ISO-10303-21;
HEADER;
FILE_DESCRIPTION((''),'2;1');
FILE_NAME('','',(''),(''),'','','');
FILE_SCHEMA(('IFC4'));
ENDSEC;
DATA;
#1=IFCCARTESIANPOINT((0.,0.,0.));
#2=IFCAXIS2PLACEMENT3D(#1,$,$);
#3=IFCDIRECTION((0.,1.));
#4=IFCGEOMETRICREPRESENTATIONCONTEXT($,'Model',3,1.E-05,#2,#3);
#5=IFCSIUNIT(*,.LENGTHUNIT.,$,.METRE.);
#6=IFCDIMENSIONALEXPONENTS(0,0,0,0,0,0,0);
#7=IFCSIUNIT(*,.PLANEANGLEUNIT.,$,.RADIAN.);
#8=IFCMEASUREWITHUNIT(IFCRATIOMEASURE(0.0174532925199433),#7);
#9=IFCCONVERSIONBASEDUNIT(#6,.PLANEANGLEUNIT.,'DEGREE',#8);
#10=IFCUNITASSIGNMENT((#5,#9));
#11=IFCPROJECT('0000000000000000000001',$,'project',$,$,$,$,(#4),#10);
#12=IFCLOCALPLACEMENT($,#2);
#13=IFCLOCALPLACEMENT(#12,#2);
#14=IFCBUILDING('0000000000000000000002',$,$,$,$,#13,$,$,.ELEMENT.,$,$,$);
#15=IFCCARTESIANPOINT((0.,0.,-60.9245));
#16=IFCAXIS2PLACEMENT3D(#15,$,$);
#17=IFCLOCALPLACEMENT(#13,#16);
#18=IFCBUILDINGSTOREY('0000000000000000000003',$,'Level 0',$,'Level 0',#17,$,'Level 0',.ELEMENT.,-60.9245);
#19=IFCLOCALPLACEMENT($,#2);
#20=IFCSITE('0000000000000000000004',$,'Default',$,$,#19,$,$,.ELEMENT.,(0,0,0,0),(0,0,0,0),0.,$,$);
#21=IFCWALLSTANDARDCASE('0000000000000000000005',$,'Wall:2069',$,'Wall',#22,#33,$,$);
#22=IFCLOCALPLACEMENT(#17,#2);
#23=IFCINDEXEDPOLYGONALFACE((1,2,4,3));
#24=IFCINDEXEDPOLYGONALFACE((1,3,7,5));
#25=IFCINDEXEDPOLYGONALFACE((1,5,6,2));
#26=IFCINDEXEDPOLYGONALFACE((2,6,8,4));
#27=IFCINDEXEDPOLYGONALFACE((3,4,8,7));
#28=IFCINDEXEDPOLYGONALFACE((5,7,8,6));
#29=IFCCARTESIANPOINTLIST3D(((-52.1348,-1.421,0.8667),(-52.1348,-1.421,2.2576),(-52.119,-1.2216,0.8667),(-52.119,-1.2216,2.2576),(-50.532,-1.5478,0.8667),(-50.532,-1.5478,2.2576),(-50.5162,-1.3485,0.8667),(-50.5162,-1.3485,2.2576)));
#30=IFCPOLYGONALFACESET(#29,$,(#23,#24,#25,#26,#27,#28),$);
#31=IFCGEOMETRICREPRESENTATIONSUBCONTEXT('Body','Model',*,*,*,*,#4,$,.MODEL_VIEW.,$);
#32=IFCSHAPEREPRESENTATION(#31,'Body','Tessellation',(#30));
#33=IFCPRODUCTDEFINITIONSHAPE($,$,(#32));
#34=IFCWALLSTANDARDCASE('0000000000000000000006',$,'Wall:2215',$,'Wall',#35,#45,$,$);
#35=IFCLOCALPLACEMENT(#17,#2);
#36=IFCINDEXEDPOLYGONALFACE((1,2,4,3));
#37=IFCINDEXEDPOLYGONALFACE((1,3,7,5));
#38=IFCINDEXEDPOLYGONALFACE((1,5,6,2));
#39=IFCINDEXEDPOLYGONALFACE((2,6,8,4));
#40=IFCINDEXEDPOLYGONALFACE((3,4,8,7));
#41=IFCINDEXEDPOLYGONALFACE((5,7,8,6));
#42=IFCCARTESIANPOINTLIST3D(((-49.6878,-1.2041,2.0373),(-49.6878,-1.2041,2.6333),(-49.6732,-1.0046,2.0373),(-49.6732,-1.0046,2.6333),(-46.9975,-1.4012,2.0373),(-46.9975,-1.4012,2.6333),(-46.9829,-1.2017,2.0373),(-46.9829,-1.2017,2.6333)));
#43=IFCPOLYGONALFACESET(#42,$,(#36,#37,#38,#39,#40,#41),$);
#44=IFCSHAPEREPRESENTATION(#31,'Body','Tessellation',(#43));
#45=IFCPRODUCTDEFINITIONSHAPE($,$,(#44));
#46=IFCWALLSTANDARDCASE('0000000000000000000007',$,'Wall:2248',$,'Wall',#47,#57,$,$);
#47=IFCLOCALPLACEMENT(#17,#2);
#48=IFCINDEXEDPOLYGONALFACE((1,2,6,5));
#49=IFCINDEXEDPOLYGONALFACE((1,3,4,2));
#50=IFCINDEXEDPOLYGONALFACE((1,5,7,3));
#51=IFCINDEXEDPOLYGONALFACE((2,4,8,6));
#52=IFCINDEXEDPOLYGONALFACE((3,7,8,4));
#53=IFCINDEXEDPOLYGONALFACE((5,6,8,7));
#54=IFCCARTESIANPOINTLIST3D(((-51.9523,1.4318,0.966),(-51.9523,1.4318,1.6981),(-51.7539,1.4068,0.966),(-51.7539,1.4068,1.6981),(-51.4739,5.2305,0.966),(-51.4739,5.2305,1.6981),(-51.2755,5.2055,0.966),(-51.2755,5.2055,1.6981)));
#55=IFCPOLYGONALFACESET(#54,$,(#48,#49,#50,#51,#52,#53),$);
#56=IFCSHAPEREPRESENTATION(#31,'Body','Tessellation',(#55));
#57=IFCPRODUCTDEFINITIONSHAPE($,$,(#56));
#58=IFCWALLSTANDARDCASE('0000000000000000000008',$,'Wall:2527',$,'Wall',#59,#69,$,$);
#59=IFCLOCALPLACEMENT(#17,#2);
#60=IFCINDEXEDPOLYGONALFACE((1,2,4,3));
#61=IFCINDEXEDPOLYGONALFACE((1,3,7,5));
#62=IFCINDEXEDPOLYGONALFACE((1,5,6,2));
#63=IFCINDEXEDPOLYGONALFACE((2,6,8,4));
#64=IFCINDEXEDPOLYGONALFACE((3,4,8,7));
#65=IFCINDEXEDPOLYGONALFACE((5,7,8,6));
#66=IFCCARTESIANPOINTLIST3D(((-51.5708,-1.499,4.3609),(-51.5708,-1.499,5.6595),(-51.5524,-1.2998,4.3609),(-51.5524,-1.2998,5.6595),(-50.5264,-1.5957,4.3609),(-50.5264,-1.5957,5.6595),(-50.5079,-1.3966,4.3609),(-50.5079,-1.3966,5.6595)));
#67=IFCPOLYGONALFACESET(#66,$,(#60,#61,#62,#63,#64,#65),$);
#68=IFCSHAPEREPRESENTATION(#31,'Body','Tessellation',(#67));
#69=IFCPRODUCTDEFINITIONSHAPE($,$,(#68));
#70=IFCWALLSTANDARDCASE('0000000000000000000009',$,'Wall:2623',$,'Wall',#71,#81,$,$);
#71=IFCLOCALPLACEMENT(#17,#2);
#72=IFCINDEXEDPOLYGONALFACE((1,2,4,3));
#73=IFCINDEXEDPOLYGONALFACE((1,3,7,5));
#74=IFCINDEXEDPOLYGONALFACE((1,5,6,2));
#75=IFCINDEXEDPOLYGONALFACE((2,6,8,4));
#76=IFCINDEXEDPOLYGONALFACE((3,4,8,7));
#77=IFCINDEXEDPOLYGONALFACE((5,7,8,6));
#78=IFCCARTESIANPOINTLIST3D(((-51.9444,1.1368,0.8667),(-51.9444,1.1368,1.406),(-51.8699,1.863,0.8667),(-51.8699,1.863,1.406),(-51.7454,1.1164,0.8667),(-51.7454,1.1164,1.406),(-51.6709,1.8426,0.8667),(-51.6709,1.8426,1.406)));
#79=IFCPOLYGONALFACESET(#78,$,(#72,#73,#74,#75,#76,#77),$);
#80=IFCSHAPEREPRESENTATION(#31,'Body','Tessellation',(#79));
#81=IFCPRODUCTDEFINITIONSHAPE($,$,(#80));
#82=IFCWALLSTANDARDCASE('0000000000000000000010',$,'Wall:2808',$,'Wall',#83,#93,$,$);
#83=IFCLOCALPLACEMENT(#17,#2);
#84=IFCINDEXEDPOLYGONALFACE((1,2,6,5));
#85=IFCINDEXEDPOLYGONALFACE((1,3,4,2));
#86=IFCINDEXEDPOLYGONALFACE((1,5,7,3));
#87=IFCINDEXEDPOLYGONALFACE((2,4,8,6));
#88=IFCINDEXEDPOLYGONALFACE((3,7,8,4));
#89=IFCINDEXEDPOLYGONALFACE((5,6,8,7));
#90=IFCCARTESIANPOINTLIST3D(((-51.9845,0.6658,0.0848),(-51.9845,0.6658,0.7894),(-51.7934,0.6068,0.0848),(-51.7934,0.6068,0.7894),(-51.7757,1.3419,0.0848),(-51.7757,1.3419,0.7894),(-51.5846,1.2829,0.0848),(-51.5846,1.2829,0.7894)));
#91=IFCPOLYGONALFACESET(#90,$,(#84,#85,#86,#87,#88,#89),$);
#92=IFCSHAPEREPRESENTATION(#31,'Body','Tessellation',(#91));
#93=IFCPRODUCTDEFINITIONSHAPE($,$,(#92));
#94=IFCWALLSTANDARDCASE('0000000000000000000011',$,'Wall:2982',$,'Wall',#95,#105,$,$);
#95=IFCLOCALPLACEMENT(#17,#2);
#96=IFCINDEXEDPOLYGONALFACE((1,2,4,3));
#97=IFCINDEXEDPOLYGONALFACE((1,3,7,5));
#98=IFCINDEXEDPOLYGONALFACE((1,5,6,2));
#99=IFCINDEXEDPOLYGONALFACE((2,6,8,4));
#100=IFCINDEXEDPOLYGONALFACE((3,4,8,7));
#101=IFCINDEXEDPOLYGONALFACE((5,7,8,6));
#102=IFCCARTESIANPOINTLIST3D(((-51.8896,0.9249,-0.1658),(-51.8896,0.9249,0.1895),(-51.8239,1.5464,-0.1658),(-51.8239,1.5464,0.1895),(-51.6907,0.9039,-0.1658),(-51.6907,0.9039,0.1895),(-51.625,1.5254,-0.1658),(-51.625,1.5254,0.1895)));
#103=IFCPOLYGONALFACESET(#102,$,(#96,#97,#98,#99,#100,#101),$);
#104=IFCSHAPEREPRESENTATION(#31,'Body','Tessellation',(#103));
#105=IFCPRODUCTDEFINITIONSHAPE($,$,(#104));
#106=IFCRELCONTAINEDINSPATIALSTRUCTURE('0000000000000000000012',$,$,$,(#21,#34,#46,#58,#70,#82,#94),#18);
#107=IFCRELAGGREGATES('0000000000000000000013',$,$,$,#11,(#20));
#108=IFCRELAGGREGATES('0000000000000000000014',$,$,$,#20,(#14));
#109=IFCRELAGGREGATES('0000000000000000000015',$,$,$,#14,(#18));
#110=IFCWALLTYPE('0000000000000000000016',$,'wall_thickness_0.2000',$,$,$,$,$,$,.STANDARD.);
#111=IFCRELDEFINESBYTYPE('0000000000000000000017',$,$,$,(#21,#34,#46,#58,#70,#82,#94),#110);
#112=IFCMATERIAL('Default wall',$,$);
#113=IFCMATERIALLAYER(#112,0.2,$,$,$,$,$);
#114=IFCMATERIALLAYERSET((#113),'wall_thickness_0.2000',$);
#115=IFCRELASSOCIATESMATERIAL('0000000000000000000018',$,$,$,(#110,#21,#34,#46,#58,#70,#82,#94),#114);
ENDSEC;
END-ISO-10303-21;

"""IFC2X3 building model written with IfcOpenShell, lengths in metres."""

from ifc_helpers import new_model, entity, si_unit, converted_unit, direction, frame, origin, place, context, subcontext, project, spatial, polyline, outline, extrude, material, layer, layer_set, layer_usage, type_object, element, save


model = new_model("IFC2X3")

# Units and contexts
model_context = context("Model", 3, precision=1e-05, world=origin(), true_north=direction((0.0, 1.0)))
body_context = subcontext(model_context, "Body", "Model", "MODEL_VIEW")
ifc_project = project(units=[si_unit("LENGTHUNIT", "METRE"), converted_unit("PLANEANGLEUNIT", "DEGREE", entity("IfcRatioMeasure", 0.0174532925199433), si_unit("PLANEANGLEUNIT", "RADIAN"), dimensions=[0, 0, 0, 0, 0, 0, 0])], contexts=[model_context])

# Site, building, storey
site_placement = place(None, origin())
site = spatial("IfcSite", under=ifc_project, at=site_placement, Name="Default", CompositionType="ELEMENT", RefLatitude=(0, 0, 0, 0), RefLongitude=(0, 0, 0, 0), RefElevation=0.0)
placement_1 = place(None, origin())
building_placement = place(placement_1, origin())
building = spatial("IfcBuilding", under=site, at=building_placement, CompositionType="ELEMENT")
storey_placement = place(building_placement, frame((0.0, 0.0, -60.9245)))
storey = spatial("IfcBuildingStorey", under=building, at=storey_placement, Name="Level 0", ObjectType="Level 0", LongName="Level 0", CompositionType="ELEMENT", Elevation=-60.9245)

# Walls
ifc_material = material(Name="Default wall")
ifc_layer = layer(ifc_material, 0.2)
ifc_layer_set = layer_set([ifc_layer], Name="wall_thickness_0.2000")
ifc_layer_usage = layer_usage(ifc_layer_set, "AXIS2", "POSITIVE", -0.1)
wall_type = type_object("IfcWallType", Name="wall_thickness_0.2000", PredefinedType="STANDARD", material=ifc_layer_set)
placement_2 = place(building_placement, frame((0.0, 0.0, -60.0578)))
wall_1_placement = place(placement_2, frame((-50.5241, -1.4482, 0.0), z_axis=(0.0, 0.0, 1.0), x_axis=(-0.996884, 0.078885, 0.0)))
element("IfcWallStandardCase", 1, at=wall_1_placement, inside=storey, type_object=wall_type, material=ifc_layer_usage, Name="Wall:2069", ObjectType="Wall", context=body_context, shape_type="SweptSolid", body=[
    extrude(outline(polyline([(1.6078, -0.1), (1.6078, 0.1), (0.0, 0.1), (0.0, -0.1), (1.6078, -0.1)])), origin(), (0.0, 0.0, 1.0), 1.3909),
])
placement_3 = place(building_placement, frame((0.0, 0.0, -58.8872)))
wall_2_placement = place(placement_3, frame((-49.6805, -1.1044, 0.0), z_axis=(0.0, 0.0, 1.0), x_axis=(0.997327, -0.073063, 0.0)))
element("IfcWallStandardCase", 2, at=wall_2_placement, inside=storey, type_object=wall_type, material=ifc_layer_usage, Name="Wall:2215", ObjectType="Wall", context=body_context, shape_type="SweptSolid", body=[
    extrude(outline(polyline([(2.6975, -0.1), (2.6975, 0.1), (0.0, 0.1), (0.0, -0.1), (2.6975, -0.1)])), origin(), (0.0, 0.0, 1.0), 0.596),
])
placement_4 = place(building_placement, frame((0.0, 0.0, -59.9585)))
wall_3_placement = place(placement_4, frame((-51.8531, 1.4193, 0.0), z_axis=(0.0, 0.0, 1.0), x_axis=(0.124951, 0.992163, 0.0)))
element("IfcWallStandardCase", 3, at=wall_3_placement, inside=storey, type_object=wall_type, material=ifc_layer_usage, Name="Wall:2248", ObjectType="Wall", context=body_context, shape_type="SweptSolid", body=[
    extrude(outline(polyline([(3.8288, -0.1), (3.8288, 0.1), (0.0, 0.1), (0.0, -0.1), (3.8288, -0.1)])), origin(), (0.0, 0.0, 1.0), 0.7321),
])
placement_5 = place(building_placement, frame((0.0, 0.0, -56.5636)))
wall_4_placement = place(placement_5, frame((-51.5616, -1.3994, 0.0), z_axis=(0.0, 0.0, 1.0), x_axis=(0.995739, -0.09222, 0.0)))
element("IfcWallStandardCase", 4, at=wall_4_placement, inside=storey, type_object=wall_type, material=ifc_layer_usage, Name="Wall:2527", ObjectType="Wall", context=body_context, shape_type="SweptSolid", body=[
    extrude(outline(polyline([(1.0489, -0.1), (1.0489, 0.1), (0.0, 0.1), (0.0, -0.1), (1.0489, -0.1)])), origin(), (0.0, 0.0, 1.0), 1.2985),
])
placement_6 = place(building_placement, frame((0.0, 0.0, -60.0578)))
wall_5_placement = place(placement_6, frame((-51.8449, 1.1266, 0.0), z_axis=(0.0, 0.0, 1.0), x_axis=(0.102082, 0.994776, 0.0)))
element("IfcWallStandardCase", 5, at=wall_5_placement, inside=storey, type_object=wall_type, material=ifc_layer_usage, Name="Wall:2623", ObjectType="Wall", context=body_context, shape_type="SweptSolid", body=[
    extrude(outline(polyline([(0.73, -0.1), (0.73, 0.1), (0.0, 0.1), (0.0, -0.1), (0.73, -0.1)])), origin(), (0.0, 0.0, 1.0), 0.5393),
])
placement_7 = place(building_placement, frame((0.0, 0.0, -60.8397)))
wall_6_placement = place(placement_7, frame((-51.6802, 1.3124, 0.0), z_axis=(0.0, 0.0, 1.0), x_axis=(-0.295057, -0.95548, 0.0)))
element("IfcWallStandardCase", 6, at=wall_6_placement, inside=storey, type_object=wall_type, material=ifc_layer_usage, Name="Wall:2808", ObjectType="Wall", context=body_context, shape_type="SweptSolid", body=[
    extrude(outline(polyline([(0.7076, -0.1), (0.7076, 0.1), (0.0, 0.1), (0.0, -0.1), (0.7076, -0.1)])), origin(), (0.0, 0.0, 1.0), 0.7047),
])
placement_8 = place(building_placement, frame((0.0, 0.0, -61.0903)))
wall_7_placement = place(placement_8, frame((-51.7245, 1.5359, 0.0), z_axis=(0.0, 0.0, 1.0), x_axis=(-0.105121, -0.994459, 0.0)))
element("IfcWallStandardCase", 7, at=wall_7_placement, inside=storey, type_object=wall_type, material=ifc_layer_usage, Name="Wall:2982", ObjectType="Wall", context=body_context, shape_type="SweptSolid", body=[
    extrude(outline(polyline([(0.625, -0.1), (0.625, 0.1), (0.0, 0.1), (0.0, -0.1), (0.625, -0.1)])), origin(), (0.0, 0.0, 1.0), 0.3553),
])

save(model, "model.ifc")
